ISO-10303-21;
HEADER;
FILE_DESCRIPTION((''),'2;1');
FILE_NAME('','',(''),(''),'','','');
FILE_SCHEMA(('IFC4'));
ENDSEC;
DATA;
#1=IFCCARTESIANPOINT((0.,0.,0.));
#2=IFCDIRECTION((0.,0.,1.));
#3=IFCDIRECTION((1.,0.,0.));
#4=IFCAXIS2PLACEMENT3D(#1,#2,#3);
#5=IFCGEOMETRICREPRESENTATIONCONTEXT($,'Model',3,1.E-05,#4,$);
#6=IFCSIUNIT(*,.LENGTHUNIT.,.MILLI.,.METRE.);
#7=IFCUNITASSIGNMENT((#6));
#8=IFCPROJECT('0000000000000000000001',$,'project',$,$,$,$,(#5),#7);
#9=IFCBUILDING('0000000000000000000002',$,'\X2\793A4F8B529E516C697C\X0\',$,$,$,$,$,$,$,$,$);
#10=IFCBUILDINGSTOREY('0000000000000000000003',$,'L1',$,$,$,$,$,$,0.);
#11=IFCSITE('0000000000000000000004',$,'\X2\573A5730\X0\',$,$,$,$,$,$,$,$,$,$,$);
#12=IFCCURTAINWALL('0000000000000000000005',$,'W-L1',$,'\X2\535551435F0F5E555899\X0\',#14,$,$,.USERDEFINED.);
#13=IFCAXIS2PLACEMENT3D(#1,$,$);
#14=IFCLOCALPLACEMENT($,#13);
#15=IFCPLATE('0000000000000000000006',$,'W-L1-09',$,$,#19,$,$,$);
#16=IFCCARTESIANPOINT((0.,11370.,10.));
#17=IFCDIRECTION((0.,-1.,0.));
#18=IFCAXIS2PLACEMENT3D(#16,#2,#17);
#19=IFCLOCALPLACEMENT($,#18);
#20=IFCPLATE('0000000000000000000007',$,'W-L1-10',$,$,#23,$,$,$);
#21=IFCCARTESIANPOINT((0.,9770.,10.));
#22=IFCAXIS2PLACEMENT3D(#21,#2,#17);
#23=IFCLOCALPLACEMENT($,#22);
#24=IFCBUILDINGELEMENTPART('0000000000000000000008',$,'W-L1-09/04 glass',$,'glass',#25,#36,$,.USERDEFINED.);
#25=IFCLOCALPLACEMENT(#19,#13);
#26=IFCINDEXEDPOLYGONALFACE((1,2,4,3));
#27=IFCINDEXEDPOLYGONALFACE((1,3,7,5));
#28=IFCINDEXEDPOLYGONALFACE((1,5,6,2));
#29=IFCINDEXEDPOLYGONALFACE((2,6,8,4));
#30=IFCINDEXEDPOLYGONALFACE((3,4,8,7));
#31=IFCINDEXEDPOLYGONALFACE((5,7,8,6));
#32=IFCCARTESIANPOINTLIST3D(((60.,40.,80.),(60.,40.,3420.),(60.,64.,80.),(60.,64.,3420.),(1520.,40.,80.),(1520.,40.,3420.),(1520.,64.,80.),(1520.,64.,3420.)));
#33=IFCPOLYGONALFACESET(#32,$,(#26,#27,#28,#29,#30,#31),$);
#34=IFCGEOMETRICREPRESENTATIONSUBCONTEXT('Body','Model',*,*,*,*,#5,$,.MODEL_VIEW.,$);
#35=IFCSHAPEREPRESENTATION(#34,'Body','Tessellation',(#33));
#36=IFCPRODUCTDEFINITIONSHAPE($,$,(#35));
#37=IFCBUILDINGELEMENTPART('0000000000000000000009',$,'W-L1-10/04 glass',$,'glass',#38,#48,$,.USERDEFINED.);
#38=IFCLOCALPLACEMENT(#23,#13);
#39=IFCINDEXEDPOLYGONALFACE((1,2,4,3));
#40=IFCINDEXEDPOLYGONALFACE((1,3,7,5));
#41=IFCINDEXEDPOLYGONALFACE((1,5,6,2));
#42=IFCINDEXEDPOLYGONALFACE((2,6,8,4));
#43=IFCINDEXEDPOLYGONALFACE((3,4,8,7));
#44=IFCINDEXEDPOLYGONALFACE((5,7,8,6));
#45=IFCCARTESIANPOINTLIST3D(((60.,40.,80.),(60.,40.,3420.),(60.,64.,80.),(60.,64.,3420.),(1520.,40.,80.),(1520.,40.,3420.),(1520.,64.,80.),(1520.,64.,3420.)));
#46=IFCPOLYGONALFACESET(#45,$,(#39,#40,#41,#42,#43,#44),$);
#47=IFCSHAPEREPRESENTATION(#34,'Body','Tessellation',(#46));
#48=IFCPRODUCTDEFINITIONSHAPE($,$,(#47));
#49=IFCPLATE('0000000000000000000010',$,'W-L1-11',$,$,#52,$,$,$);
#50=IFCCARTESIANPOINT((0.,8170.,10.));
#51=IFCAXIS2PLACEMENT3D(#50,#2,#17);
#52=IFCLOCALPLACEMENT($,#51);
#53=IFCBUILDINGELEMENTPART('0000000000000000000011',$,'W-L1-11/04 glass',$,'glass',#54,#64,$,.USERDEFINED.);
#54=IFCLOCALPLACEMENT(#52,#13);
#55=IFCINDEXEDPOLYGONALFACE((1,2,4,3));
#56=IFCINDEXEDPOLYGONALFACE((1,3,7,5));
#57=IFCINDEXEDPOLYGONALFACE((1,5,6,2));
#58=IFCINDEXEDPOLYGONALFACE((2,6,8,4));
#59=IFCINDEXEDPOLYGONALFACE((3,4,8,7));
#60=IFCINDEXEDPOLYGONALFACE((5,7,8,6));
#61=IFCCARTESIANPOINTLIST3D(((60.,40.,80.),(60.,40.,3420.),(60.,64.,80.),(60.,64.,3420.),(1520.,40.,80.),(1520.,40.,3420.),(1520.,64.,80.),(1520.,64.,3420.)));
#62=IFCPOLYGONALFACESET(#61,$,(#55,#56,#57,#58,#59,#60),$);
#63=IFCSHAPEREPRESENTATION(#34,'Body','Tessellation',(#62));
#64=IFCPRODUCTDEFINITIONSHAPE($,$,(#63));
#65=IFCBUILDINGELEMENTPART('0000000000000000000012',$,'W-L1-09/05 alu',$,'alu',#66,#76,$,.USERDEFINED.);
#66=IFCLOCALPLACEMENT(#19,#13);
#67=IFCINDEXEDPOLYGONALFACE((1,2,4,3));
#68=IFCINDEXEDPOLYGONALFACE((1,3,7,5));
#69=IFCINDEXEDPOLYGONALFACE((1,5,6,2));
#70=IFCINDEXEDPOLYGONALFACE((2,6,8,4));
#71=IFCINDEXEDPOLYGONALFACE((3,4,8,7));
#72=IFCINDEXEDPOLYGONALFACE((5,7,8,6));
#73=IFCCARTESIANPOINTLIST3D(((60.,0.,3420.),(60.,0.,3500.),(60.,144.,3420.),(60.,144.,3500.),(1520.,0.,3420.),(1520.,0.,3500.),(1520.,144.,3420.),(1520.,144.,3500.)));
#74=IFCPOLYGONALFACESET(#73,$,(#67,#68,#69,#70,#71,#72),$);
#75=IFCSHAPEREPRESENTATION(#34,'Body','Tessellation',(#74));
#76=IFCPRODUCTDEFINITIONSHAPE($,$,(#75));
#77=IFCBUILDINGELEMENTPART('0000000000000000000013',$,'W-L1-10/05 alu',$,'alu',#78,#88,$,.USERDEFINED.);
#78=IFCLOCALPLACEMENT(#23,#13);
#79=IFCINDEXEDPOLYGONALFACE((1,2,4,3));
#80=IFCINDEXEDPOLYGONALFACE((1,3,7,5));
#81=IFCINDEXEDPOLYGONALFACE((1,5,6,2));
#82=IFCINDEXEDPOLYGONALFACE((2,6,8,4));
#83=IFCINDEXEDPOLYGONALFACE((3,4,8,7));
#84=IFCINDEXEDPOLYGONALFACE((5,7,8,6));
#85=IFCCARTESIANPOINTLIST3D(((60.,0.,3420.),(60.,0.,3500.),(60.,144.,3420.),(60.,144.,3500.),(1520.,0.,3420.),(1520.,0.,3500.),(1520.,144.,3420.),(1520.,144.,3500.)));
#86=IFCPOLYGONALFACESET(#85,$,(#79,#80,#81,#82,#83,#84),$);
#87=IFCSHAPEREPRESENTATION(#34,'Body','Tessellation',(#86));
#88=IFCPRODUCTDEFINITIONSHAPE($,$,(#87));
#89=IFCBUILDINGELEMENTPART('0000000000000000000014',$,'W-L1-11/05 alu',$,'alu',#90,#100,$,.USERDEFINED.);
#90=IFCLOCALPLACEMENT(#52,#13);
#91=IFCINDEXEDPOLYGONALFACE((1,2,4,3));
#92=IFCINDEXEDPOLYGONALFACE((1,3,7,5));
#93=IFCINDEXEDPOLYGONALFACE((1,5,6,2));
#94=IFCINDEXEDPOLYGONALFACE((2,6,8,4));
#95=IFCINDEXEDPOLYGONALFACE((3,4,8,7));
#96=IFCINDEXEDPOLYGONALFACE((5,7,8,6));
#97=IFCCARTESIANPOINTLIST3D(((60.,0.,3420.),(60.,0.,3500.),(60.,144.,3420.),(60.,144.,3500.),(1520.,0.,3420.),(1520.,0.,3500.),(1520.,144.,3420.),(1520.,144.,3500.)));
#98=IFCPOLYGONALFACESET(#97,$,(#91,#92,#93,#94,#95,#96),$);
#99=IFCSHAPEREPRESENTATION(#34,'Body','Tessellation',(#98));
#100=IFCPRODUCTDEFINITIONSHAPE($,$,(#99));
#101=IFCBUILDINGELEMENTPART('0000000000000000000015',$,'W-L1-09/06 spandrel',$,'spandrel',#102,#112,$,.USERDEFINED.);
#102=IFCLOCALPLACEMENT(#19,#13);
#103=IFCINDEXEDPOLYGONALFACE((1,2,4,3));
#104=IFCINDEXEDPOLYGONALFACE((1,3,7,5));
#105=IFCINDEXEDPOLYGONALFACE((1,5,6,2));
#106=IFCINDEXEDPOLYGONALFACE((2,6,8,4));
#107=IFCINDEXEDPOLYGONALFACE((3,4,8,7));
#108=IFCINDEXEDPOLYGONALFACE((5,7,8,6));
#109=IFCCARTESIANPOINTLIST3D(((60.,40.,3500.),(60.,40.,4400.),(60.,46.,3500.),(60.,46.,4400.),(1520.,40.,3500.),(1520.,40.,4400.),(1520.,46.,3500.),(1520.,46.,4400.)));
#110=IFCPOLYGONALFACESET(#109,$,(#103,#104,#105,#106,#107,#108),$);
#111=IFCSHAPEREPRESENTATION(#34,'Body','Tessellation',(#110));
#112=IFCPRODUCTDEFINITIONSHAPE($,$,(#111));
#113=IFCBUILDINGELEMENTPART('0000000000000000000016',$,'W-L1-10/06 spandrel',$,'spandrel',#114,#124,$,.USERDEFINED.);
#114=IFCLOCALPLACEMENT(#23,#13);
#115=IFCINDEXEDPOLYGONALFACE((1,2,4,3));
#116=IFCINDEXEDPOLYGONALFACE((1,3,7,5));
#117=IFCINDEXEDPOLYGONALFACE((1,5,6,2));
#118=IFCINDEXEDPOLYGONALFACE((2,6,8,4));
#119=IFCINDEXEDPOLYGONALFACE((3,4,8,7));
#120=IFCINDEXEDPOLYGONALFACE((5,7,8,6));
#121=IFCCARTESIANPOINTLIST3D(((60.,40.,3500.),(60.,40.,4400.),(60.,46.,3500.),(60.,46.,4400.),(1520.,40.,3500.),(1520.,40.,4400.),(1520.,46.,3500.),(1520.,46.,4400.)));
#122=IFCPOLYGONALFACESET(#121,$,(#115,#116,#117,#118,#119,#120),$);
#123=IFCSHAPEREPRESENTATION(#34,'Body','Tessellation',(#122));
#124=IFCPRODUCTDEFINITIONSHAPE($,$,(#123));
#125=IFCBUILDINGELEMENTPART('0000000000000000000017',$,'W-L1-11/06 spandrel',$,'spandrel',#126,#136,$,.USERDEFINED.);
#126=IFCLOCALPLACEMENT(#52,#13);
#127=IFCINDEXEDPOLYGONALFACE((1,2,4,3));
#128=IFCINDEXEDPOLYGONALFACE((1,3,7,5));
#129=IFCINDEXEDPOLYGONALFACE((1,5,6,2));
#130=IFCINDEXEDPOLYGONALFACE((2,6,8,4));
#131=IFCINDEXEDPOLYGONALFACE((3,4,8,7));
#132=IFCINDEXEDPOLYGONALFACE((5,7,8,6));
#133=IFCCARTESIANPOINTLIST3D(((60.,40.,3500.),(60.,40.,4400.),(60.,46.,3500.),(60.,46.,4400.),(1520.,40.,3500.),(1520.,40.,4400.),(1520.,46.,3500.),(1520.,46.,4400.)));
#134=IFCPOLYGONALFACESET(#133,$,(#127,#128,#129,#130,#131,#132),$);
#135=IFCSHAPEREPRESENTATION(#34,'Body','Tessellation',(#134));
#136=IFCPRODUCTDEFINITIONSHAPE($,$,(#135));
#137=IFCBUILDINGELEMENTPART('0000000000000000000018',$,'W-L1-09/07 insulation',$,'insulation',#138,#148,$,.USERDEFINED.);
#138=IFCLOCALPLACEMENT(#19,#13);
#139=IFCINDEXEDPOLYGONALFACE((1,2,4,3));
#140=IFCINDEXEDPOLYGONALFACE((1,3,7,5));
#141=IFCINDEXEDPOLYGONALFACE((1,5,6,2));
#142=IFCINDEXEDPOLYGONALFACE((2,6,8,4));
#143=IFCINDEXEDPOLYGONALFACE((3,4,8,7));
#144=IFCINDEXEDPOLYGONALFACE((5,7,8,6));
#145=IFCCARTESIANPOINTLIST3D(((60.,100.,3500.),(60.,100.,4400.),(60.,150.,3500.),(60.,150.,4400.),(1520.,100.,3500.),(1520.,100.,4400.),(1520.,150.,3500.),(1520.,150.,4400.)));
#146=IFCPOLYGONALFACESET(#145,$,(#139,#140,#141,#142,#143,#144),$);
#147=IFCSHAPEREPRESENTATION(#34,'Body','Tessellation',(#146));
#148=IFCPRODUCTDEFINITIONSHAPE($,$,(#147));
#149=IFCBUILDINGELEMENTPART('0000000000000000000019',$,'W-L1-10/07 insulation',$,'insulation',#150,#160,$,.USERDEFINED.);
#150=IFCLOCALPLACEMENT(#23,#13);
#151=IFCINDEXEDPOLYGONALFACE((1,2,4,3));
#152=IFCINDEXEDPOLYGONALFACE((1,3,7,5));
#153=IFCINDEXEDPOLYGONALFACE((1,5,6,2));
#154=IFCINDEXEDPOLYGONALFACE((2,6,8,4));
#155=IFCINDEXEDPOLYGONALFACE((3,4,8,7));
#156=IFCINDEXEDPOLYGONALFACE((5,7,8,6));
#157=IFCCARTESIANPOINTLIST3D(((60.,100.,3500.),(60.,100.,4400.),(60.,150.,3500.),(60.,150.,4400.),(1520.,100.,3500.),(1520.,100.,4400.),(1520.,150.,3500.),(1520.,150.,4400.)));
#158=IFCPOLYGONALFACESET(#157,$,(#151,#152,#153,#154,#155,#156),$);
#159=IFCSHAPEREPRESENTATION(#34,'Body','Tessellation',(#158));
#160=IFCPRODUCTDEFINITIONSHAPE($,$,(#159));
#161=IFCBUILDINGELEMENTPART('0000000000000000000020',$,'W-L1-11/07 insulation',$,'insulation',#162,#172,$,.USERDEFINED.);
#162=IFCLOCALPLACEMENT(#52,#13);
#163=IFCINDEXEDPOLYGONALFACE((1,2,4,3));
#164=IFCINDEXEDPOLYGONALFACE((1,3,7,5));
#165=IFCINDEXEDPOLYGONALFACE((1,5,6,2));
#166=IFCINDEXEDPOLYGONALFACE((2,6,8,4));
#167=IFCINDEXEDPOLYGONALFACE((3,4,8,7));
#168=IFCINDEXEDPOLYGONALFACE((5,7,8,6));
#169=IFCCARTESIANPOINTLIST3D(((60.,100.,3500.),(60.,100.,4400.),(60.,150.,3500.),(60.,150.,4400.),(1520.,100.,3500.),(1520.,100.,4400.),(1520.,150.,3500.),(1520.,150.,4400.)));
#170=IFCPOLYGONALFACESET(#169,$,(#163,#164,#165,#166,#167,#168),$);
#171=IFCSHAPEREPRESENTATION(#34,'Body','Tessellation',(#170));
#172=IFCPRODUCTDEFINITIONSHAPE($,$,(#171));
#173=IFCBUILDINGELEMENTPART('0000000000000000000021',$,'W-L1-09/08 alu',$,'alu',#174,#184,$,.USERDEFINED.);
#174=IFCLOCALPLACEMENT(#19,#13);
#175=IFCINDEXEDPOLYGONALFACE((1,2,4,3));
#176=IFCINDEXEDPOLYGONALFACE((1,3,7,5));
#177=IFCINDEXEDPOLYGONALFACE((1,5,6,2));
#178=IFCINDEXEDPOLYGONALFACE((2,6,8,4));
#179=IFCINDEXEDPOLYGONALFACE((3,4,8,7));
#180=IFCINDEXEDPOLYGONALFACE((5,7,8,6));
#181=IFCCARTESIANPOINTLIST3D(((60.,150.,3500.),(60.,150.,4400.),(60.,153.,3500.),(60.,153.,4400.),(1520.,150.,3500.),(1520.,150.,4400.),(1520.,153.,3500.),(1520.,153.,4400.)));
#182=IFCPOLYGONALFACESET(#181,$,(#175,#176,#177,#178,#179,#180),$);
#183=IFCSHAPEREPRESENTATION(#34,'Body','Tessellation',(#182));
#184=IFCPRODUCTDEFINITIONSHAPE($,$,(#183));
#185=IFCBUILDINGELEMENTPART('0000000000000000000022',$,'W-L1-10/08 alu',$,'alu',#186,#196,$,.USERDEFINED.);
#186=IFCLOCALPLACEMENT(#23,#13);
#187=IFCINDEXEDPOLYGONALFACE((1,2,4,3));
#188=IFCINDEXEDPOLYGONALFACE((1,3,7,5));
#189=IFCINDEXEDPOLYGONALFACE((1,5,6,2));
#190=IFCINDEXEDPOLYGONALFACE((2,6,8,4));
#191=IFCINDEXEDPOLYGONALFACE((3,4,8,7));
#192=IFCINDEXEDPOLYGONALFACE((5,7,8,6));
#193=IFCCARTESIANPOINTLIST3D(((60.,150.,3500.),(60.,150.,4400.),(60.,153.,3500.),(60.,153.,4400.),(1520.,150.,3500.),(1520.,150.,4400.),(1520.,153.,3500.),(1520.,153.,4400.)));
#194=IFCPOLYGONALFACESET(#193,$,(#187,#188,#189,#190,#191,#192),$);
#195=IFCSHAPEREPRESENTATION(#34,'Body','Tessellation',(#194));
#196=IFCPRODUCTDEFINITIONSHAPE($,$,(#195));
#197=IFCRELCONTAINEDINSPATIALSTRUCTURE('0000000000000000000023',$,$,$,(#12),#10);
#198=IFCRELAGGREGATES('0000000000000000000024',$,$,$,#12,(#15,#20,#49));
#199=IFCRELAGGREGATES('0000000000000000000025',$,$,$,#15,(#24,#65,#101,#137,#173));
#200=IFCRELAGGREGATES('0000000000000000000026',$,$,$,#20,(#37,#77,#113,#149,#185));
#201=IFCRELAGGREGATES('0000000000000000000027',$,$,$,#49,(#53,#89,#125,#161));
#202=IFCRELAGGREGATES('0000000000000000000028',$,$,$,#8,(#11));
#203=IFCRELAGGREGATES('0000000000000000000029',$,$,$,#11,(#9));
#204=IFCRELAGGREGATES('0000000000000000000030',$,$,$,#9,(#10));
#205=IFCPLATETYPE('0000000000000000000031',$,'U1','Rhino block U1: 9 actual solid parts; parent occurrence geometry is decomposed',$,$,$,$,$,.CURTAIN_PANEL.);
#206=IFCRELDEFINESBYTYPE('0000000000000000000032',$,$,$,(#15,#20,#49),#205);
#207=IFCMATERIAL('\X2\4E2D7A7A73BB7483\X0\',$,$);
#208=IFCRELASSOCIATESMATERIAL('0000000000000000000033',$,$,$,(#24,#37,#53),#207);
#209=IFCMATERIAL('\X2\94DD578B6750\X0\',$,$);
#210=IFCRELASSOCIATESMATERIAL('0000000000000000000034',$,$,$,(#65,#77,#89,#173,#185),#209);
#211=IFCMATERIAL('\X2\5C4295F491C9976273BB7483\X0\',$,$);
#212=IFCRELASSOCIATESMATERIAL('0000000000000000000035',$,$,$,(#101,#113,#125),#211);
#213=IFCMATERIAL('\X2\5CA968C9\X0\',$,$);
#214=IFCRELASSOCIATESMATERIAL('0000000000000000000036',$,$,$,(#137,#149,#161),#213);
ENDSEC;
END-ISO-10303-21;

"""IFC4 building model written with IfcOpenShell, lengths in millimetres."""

from ifc_helpers import new_model, si_unit, frame, frame_2d, origin, origin_with_axes, place, context, subcontext, project, spatial, rectangle, extrude, source, transform, mapped, material, type_object, element, aggregate, save


model = new_model("IFC4")

# Units and contexts
model_context = context("Model", 3, precision=1e-05, world=origin_with_axes())
body_context = subcontext(model_context, "Body", "Model", "MODEL_VIEW")
ifc_project = project(units=[si_unit("LENGTHUNIT", "METRE", prefix="MILLI")], contexts=[model_context])

# Site, building, storey
site = spatial("IfcSite", under=ifc_project, Name="场地")
building = spatial("IfcBuilding", under=site, Name="示例办公楼")
storey = spatial("IfcBuildingStorey", under=building, Name="L1", Elevation=0.0)

# Curtain wall, plates, building element parts
curtain_wall = element("IfcCurtainWall", 1, inside=storey, Name="W-L1", ObjectType="单元式幕墙", PredefinedType="USERDEFINED")
plate_type = type_object("IfcPlateType", Name="U1", Description="Rhino block U1: 9 actual solid parts; parent occurrence geometry is decomposed", PredefinedType="CURTAIN_PANEL")
ifc_material_1 = material(Name="铝型材")
plate_1_placement = place(None, frame((0.0, 11370.0, 10.0), z_axis=(0.0, 0.0, 1.0), x_axis=(0.0, -1.0, 0.0)))
plate_1 = element("IfcPlate", 2, at=plate_1_placement, type_object=plate_type, Name="W-L1-09")
plate_2_placement = place(None, frame((0.0, 9770.0, 10.0), z_axis=(0.0, 0.0, 1.0), x_axis=(0.0, -1.0, 0.0)))
plate_2 = element("IfcPlate", 3, at=plate_2_placement, type_object=plate_type, Name="W-L1-10")
ifc_material_2 = material(Name="中空玻璃")
shared_shape_1 = source(origin(), body_context, "Body", "SweptSolid", [
    extrude(rectangle(XDim=1460.0, YDim=24.0, at=frame_2d((790.0, 52.0))), frame((0.0, 0.0, 80.0)), (0.0, 0.0, 1.0), 3340.0),
])
building_element_part_1_placement = place(plate_1_placement, origin())
building_element_part_1 = element("IfcBuildingElementPart", 4, at=building_element_part_1_placement, material=ifc_material_2, Name="W-L1-09/04 glass", ObjectType="glass", PredefinedType="USERDEFINED", context=body_context, shape_type="MappedRepresentation", body=[
    mapped(shared_shape_1, transform((0.0, 0.0, 0.0))),
])
building_element_part_2_placement = place(plate_2_placement, origin())
building_element_part_2 = element("IfcBuildingElementPart", 5, at=building_element_part_2_placement, material=ifc_material_2, Name="W-L1-10/04 glass", ObjectType="glass", PredefinedType="USERDEFINED", context=body_context, shape_type="MappedRepresentation", body=[
    mapped(shared_shape_1, transform((0.0, 0.0, 0.0))),
])
plate_3_placement = place(None, frame((0.0, 8170.0, 10.0), z_axis=(0.0, 0.0, 1.0), x_axis=(0.0, -1.0, 0.0)))
plate_3 = element("IfcPlate", 6, at=plate_3_placement, type_object=plate_type, Name="W-L1-11")
aggregate(curtain_wall, [plate_1, plate_2, plate_3])
building_element_part_3_placement = place(plate_3_placement, origin())
building_element_part_3 = element("IfcBuildingElementPart", 7, at=building_element_part_3_placement, material=ifc_material_2, Name="W-L1-11/04 glass", ObjectType="glass", PredefinedType="USERDEFINED", context=body_context, shape_type="MappedRepresentation", body=[
    mapped(shared_shape_1, transform((0.0, 0.0, 0.0))),
])
shared_shape_2 = source(origin(), body_context, "Body", "SweptSolid", [
    extrude(rectangle(XDim=1460.0, YDim=144.0, at=frame_2d((790.0, 72.0))), frame((0.0, 0.0, 3420.0)), (0.0, 0.0, 1.0), 80.0),
])
building_element_part_4_placement = place(plate_1_placement, origin())
building_element_part_4 = element("IfcBuildingElementPart", 8, at=building_element_part_4_placement, material=ifc_material_1, Name="W-L1-09/05 alu", ObjectType="alu", PredefinedType="USERDEFINED", context=body_context, shape_type="MappedRepresentation", body=[
    mapped(shared_shape_2, transform((0.0, 0.0, 0.0))),
])
building_element_part_5_placement = place(plate_2_placement, origin())
building_element_part_5 = element("IfcBuildingElementPart", 9, at=building_element_part_5_placement, material=ifc_material_1, Name="W-L1-10/05 alu", ObjectType="alu", PredefinedType="USERDEFINED", context=body_context, shape_type="MappedRepresentation", body=[
    mapped(shared_shape_2, transform((0.0, 0.0, 0.0))),
])
building_element_part_6_placement = place(plate_3_placement, origin())
building_element_part_6 = element("IfcBuildingElementPart", 10, at=building_element_part_6_placement, material=ifc_material_1, Name="W-L1-11/05 alu", ObjectType="alu", PredefinedType="USERDEFINED", context=body_context, shape_type="MappedRepresentation", body=[
    mapped(shared_shape_2, transform((0.0, 0.0, 0.0))),
])
ifc_material_3 = material(Name="层间釉面玻璃")
shared_shape_3 = source(origin(), body_context, "Body", "SweptSolid", [
    extrude(rectangle(XDim=1460.0, YDim=6.0, at=frame_2d((790.0, 43.0))), frame((0.0, 0.0, 3500.0)), (0.0, 0.0, 1.0), 900.0),
])
building_element_part_7_placement = place(plate_1_placement, origin())
building_element_part_7 = element("IfcBuildingElementPart", 11, at=building_element_part_7_placement, material=ifc_material_3, Name="W-L1-09/06 spandrel", ObjectType="spandrel", PredefinedType="USERDEFINED", context=body_context, shape_type="MappedRepresentation", body=[
    mapped(shared_shape_3, transform((0.0, 0.0, 0.0))),
])
building_element_part_8_placement = place(plate_2_placement, origin())
building_element_part_8 = element("IfcBuildingElementPart", 12, at=building_element_part_8_placement, material=ifc_material_3, Name="W-L1-10/06 spandrel", ObjectType="spandrel", PredefinedType="USERDEFINED", context=body_context, shape_type="MappedRepresentation", body=[
    mapped(shared_shape_3, transform((0.0, 0.0, 0.0))),
])
building_element_part_9_placement = place(plate_3_placement, origin())
building_element_part_9 = element("IfcBuildingElementPart", 13, at=building_element_part_9_placement, material=ifc_material_3, Name="W-L1-11/06 spandrel", ObjectType="spandrel", PredefinedType="USERDEFINED", context=body_context, shape_type="MappedRepresentation", body=[
    mapped(shared_shape_3, transform((0.0, 0.0, 0.0))),
])
ifc_material_4 = material(Name="岩棉")
shared_shape_4 = source(origin(), body_context, "Body", "SweptSolid", [
    extrude(rectangle(XDim=1460.0, YDim=50.0, at=frame_2d((790.0, 125.0))), frame((0.0, 0.0, 3500.0)), (0.0, 0.0, 1.0), 900.0),
])
building_element_part_10_placement = place(plate_1_placement, origin())
building_element_part_10 = element("IfcBuildingElementPart", 14, at=building_element_part_10_placement, material=ifc_material_4, Name="W-L1-09/07 insulation", ObjectType="insulation", PredefinedType="USERDEFINED", context=body_context, shape_type="MappedRepresentation", body=[
    mapped(shared_shape_4, transform((0.0, 0.0, 0.0))),
])
building_element_part_11_placement = place(plate_2_placement, origin())
building_element_part_11 = element("IfcBuildingElementPart", 15, at=building_element_part_11_placement, material=ifc_material_4, Name="W-L1-10/07 insulation", ObjectType="insulation", PredefinedType="USERDEFINED", context=body_context, shape_type="MappedRepresentation", body=[
    mapped(shared_shape_4, transform((0.0, 0.0, 0.0))),
])
building_element_part_12_placement = place(plate_3_placement, origin())
building_element_part_12 = element("IfcBuildingElementPart", 16, at=building_element_part_12_placement, material=ifc_material_4, Name="W-L1-11/07 insulation", ObjectType="insulation", PredefinedType="USERDEFINED", context=body_context, shape_type="MappedRepresentation", body=[
    mapped(shared_shape_4, transform((0.0, 0.0, 0.0))),
])
shared_shape_5 = source(origin(), body_context, "Body", "SweptSolid", [
    extrude(rectangle(XDim=1460.0, YDim=3.0, at=frame_2d((790.0, 151.5))), frame((0.0, 0.0, 3500.0)), (0.0, 0.0, 1.0), 900.0),
])
building_element_part_13_placement = place(plate_1_placement, origin())
building_element_part_13 = element("IfcBuildingElementPart", 17, at=building_element_part_13_placement, material=ifc_material_1, Name="W-L1-09/08 alu", ObjectType="alu", PredefinedType="USERDEFINED", context=body_context, shape_type="MappedRepresentation", body=[
    mapped(shared_shape_5, transform((0.0, 0.0, 0.0))),
])
building_element_part_14_placement = place(plate_2_placement, origin())
building_element_part_14 = element("IfcBuildingElementPart", 18, at=building_element_part_14_placement, material=ifc_material_1, Name="W-L1-10/08 alu", ObjectType="alu", PredefinedType="USERDEFINED", context=body_context, shape_type="MappedRepresentation", body=[
    mapped(shared_shape_5, transform((0.0, 0.0, 0.0))),
])
aggregate(plate_1, [building_element_part_1, building_element_part_4, building_element_part_7, building_element_part_10, building_element_part_13])
aggregate(plate_2, [building_element_part_2, building_element_part_5, building_element_part_8, building_element_part_11, building_element_part_14])
aggregate(plate_3, [building_element_part_3, building_element_part_6, building_element_part_9, building_element_part_12])

save(model, "model.ifc")
